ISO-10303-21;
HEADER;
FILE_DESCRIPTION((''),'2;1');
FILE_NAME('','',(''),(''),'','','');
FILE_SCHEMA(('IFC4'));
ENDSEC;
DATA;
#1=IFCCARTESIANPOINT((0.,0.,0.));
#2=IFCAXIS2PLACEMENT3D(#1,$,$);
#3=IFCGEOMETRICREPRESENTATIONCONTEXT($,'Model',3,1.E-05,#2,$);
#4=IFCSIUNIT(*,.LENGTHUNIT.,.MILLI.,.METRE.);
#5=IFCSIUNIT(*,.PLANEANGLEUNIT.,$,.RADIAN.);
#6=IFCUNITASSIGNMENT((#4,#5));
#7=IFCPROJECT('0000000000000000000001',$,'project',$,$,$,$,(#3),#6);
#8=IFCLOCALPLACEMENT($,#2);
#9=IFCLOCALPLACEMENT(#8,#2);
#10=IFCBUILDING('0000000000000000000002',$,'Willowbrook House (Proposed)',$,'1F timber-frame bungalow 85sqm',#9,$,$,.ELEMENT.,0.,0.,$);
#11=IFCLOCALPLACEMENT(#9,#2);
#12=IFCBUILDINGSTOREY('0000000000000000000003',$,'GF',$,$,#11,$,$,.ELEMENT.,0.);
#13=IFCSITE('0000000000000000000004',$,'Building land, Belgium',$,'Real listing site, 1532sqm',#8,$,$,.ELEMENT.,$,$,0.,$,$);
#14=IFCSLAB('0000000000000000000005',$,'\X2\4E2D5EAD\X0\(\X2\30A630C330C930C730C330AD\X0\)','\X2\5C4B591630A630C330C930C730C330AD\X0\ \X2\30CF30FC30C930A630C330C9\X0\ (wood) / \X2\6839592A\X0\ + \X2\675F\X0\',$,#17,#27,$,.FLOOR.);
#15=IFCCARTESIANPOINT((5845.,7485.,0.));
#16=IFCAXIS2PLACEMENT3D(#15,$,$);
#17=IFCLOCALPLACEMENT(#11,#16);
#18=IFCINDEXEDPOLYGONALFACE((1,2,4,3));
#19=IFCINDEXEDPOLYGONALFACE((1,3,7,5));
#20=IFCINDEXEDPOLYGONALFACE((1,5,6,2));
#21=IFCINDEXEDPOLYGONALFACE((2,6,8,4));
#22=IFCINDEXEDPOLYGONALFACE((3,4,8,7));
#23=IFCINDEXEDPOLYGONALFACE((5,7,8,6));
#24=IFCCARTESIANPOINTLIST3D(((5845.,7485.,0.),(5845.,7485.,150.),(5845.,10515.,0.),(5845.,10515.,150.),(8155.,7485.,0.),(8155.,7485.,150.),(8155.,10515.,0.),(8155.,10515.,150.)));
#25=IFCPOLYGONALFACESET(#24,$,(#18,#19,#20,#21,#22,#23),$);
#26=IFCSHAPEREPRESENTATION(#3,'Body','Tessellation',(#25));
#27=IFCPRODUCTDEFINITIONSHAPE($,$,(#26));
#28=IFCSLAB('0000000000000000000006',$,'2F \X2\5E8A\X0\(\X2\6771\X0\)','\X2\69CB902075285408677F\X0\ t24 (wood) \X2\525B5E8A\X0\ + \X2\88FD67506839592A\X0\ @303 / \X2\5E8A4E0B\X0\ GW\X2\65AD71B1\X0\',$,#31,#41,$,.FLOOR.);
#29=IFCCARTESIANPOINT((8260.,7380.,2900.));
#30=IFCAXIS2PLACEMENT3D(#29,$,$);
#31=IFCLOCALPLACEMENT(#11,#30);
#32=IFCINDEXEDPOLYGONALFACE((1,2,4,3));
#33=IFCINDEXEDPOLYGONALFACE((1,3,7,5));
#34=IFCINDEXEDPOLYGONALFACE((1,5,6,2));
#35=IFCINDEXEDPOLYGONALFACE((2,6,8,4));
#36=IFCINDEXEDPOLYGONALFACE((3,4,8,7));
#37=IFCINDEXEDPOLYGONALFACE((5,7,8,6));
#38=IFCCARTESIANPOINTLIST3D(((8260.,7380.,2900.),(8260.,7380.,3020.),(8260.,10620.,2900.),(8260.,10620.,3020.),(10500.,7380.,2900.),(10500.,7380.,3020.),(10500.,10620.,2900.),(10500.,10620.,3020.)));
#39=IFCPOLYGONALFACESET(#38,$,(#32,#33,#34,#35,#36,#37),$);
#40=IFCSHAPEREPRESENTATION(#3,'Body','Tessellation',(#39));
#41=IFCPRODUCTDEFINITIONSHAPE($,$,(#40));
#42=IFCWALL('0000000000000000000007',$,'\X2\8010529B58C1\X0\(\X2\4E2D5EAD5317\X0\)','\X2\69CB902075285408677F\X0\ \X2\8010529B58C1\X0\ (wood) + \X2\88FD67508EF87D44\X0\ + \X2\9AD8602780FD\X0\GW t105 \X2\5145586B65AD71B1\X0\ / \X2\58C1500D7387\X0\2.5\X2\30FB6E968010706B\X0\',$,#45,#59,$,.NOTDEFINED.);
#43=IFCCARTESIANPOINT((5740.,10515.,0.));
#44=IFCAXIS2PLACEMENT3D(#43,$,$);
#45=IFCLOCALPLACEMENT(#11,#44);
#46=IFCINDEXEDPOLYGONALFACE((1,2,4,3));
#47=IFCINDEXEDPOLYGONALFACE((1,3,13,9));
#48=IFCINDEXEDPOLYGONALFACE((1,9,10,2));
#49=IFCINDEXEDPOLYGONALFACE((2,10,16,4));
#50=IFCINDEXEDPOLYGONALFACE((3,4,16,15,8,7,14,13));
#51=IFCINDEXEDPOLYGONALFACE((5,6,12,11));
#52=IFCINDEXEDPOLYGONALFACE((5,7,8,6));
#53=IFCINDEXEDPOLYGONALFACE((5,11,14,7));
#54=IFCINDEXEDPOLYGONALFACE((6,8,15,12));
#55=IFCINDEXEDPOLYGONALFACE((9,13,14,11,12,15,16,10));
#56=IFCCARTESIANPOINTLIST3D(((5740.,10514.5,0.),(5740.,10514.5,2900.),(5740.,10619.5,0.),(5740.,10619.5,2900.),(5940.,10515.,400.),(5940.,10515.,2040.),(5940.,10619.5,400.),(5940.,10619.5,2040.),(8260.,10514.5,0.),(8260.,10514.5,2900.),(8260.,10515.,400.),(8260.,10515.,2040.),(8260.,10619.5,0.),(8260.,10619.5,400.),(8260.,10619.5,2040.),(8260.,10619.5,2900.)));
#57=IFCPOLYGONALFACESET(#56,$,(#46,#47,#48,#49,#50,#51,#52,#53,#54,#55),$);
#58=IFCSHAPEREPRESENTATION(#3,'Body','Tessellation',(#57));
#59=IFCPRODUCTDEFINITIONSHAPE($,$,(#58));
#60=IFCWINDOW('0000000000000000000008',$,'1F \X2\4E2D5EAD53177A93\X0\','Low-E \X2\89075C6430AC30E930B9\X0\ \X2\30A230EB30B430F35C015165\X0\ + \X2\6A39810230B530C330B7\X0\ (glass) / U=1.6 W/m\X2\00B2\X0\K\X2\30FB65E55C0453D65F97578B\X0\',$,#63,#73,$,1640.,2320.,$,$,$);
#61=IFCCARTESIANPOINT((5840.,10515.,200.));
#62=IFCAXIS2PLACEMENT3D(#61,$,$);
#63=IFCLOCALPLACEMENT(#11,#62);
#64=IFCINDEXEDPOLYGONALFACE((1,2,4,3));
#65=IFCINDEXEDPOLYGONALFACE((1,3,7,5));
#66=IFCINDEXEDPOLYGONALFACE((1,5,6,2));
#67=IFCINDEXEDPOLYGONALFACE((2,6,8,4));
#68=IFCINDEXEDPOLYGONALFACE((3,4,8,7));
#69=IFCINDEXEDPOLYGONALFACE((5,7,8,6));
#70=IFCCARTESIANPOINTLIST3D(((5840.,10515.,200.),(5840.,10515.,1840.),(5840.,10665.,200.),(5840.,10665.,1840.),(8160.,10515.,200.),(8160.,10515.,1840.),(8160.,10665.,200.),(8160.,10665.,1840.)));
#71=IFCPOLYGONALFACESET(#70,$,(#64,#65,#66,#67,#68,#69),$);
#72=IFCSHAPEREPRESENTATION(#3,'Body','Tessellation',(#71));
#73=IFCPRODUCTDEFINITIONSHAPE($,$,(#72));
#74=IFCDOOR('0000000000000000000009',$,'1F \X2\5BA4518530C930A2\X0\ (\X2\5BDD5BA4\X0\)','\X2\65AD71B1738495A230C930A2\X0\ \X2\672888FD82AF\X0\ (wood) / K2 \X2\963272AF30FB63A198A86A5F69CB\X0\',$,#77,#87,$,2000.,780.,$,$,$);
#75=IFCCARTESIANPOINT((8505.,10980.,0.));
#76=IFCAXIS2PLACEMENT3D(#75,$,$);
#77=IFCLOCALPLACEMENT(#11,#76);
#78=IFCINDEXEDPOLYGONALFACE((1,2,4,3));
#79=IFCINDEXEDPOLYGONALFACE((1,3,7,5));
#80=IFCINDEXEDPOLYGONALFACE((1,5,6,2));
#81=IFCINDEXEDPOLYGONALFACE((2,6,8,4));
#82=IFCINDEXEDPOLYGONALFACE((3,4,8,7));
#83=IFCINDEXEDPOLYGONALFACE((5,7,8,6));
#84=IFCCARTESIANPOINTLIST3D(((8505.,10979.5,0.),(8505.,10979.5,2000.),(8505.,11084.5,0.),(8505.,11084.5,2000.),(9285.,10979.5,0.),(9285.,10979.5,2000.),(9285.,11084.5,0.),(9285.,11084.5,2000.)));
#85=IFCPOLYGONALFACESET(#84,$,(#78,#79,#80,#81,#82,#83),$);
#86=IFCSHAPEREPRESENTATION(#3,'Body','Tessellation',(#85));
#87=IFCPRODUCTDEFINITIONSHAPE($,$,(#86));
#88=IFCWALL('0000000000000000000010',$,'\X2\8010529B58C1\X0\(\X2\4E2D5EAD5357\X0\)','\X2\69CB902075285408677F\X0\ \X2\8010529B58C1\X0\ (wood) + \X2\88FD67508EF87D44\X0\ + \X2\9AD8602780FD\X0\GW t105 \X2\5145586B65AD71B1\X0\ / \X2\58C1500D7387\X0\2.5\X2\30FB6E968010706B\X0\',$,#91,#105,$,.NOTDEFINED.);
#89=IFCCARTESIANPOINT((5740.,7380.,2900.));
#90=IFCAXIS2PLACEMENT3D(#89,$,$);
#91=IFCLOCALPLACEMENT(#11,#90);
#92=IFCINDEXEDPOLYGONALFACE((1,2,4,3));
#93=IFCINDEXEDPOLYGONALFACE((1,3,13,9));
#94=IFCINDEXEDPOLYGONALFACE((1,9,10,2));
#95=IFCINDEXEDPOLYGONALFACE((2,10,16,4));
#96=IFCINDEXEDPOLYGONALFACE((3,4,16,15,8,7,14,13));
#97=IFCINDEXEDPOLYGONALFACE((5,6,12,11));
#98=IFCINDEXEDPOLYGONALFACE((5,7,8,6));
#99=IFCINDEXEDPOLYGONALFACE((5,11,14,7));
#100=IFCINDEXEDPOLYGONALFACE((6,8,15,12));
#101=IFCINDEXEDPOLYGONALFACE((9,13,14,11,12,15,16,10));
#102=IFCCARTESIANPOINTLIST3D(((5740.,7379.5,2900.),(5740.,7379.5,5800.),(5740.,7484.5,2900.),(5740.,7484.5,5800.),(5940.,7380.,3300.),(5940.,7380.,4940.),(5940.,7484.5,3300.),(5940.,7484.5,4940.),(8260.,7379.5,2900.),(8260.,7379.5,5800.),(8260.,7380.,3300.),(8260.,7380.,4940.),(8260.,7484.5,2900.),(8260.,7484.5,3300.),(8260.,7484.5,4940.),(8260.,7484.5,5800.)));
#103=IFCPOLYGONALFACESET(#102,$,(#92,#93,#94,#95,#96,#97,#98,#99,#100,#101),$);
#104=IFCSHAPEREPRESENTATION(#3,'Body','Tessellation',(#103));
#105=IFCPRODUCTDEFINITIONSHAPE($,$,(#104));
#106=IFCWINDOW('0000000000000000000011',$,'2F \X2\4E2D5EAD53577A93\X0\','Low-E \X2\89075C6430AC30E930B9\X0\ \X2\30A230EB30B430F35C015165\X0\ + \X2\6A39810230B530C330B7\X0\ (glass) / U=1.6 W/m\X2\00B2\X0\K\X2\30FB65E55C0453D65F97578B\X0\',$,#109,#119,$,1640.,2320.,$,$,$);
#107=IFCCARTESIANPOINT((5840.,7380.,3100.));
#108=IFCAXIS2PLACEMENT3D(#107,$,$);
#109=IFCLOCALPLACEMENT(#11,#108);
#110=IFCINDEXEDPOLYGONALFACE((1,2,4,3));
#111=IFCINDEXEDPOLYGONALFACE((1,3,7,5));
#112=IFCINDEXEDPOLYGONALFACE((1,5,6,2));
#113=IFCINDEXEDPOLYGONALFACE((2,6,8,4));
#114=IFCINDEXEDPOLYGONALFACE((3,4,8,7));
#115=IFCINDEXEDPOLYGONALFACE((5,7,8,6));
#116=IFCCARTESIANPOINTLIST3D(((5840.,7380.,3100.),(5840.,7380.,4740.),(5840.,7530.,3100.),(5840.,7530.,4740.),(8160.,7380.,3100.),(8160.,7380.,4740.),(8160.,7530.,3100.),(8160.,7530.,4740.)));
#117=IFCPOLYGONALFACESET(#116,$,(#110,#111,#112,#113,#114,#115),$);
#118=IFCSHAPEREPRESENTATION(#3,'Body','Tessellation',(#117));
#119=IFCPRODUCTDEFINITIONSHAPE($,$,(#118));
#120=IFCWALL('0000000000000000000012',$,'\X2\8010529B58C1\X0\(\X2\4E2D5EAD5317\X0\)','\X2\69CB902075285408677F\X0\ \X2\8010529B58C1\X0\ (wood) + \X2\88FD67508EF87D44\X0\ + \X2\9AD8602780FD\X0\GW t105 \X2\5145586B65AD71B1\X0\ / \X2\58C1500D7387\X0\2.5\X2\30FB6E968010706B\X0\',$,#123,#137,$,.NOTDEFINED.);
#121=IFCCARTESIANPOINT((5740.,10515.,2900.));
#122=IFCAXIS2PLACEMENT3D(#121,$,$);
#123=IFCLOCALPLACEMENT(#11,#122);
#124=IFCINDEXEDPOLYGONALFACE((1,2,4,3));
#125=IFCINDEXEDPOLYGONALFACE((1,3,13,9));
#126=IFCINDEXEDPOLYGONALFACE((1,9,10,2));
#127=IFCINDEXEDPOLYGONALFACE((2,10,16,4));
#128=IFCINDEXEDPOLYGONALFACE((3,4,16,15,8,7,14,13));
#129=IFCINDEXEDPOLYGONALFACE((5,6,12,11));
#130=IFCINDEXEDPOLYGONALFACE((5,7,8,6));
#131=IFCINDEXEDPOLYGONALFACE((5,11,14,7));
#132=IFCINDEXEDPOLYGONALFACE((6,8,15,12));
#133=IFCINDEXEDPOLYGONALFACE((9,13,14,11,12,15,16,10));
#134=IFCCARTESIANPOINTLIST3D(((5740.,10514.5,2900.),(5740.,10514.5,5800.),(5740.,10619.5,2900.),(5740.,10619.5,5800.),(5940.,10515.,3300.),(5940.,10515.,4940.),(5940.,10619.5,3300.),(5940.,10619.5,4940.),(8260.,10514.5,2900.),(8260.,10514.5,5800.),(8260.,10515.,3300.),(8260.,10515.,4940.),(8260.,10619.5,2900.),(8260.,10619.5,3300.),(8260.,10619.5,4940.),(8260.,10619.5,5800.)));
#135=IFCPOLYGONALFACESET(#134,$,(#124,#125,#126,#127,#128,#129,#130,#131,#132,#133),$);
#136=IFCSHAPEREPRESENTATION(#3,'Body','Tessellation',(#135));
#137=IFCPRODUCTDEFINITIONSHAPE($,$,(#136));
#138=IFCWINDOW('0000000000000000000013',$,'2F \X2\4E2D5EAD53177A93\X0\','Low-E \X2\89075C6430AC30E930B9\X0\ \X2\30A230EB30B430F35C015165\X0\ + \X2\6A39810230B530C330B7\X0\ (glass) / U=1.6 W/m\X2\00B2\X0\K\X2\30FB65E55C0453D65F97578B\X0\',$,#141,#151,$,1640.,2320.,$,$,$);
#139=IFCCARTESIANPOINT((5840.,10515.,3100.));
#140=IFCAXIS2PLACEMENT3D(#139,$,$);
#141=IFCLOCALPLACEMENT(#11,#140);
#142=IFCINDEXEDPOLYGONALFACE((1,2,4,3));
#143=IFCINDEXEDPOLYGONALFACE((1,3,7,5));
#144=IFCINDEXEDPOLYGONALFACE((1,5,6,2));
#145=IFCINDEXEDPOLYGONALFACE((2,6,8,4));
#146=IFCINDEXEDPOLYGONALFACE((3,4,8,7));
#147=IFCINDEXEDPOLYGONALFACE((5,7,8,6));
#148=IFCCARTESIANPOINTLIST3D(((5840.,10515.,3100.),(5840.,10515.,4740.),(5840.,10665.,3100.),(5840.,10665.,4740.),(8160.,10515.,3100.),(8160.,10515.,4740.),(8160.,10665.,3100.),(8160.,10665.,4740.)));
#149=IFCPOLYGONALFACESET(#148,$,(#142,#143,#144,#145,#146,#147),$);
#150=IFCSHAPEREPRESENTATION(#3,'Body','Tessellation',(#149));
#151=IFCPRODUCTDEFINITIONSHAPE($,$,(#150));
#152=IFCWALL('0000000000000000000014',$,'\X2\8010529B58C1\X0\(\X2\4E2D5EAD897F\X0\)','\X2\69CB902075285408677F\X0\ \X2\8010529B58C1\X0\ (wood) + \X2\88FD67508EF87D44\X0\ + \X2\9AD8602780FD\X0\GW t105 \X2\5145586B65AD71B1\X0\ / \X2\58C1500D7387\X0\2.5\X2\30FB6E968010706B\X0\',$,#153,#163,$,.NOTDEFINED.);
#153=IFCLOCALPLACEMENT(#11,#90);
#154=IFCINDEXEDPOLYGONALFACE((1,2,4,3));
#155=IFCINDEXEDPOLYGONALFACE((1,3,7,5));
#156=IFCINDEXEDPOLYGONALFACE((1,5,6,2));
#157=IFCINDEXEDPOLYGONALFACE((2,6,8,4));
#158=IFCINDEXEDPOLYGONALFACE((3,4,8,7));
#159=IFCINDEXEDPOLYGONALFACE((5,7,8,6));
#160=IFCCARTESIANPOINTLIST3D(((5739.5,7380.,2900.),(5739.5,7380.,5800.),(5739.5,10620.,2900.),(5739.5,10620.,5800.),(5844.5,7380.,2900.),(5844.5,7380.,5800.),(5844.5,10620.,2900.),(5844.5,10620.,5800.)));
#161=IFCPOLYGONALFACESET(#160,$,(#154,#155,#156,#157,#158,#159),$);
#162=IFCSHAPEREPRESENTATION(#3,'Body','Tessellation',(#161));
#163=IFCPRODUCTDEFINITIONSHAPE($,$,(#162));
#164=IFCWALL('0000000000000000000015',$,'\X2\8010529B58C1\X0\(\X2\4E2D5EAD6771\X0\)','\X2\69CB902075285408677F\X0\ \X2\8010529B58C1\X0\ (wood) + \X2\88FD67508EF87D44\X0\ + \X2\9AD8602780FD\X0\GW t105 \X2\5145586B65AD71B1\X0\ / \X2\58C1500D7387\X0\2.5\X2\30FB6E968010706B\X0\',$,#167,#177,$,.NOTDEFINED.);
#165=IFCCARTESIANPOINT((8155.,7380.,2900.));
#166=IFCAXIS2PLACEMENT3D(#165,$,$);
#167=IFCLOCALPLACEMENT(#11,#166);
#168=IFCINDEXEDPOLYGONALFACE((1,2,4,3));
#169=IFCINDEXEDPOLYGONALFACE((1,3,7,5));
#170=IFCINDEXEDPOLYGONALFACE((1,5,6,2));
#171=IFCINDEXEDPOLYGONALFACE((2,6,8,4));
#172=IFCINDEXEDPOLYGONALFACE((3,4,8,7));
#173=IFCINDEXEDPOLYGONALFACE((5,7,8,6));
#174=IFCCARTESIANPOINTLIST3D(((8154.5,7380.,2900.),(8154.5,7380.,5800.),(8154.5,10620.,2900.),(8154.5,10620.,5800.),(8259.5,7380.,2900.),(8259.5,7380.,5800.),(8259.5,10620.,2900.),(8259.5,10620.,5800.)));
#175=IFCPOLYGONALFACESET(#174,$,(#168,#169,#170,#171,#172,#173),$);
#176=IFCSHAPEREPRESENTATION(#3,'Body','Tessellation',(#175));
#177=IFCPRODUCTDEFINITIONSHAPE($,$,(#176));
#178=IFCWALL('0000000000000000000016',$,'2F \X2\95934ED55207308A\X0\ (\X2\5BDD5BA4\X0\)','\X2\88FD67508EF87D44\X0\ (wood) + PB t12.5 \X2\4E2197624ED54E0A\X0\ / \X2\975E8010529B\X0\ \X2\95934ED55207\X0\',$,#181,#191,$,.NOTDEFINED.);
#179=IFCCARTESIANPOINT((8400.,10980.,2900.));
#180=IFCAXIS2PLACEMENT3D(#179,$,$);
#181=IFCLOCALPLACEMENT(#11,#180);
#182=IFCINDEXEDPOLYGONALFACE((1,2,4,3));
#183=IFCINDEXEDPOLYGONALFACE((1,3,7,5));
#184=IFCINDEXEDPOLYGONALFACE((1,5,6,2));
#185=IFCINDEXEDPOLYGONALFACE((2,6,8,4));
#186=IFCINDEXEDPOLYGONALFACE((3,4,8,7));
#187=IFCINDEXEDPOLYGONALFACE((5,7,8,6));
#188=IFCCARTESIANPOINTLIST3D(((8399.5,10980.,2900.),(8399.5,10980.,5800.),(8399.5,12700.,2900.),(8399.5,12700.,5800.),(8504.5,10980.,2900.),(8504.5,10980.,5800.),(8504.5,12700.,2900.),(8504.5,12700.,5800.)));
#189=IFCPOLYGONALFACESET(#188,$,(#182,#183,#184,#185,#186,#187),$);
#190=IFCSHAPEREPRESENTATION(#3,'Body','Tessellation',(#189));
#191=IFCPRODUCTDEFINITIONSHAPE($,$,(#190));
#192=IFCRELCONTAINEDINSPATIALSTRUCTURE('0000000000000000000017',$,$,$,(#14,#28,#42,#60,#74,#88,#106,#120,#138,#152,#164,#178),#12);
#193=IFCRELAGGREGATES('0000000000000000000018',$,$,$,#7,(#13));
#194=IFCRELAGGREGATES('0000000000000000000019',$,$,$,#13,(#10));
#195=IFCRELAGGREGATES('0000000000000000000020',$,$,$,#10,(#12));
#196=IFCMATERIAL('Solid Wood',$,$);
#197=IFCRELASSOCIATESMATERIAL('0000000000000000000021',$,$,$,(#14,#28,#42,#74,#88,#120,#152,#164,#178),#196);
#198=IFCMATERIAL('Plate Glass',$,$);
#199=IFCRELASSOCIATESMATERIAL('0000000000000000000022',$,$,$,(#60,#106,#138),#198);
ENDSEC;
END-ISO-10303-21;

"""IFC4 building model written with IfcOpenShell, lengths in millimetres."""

from ifc_helpers import new_model, si_unit, frame, frame_2d, origin, place, context, project, spatial, rectangle, extrude, material, element, fill, save


model = new_model("IFC4")

# Units and contexts
model_context = context("Model", 3, precision=1e-05, world=origin())
ifc_project = project(units=[si_unit("LENGTHUNIT", "METRE", prefix="MILLI"), si_unit("PLANEANGLEUNIT", "RADIAN")], contexts=[model_context])

# Site, building, storey
site_placement = place(None, origin())
site = spatial("IfcSite", under=ifc_project, at=site_placement, Name="Building land, Belgium", ObjectType="Real listing site, 1532sqm", CompositionType="ELEMENT", RefElevation=0.0)
building_placement = place(site_placement, origin())
building = spatial("IfcBuilding", under=site, at=building_placement, Name="Willowbrook House (Proposed)", ObjectType="1F timber-frame bungalow 85sqm", CompositionType="ELEMENT", ElevationOfRefHeight=0.0, ElevationOfTerrain=0.0)
storey_placement = place(building_placement, origin())
storey = spatial("IfcBuildingStorey", under=building, at=storey_placement, Name="GF", CompositionType="ELEMENT", Elevation=0.0)

# Slabs
ifc_material_1 = material(Name="Solid Wood")
slab_1_placement = place(storey_placement, frame((5845.0, 7485.0, 0.0)))
element("IfcSlab", 1, at=slab_1_placement, inside=storey, material=ifc_material_1, Name="中庭(ウッドデッキ)", Description="屋外ウッドデッキ ハードウッド (wood) / 根太 + 束", PredefinedType="FLOOR", context=model_context, shape_type="SweptSolid", body=[
    extrude(rectangle(XDim=2310.0, YDim=3030.0, at=frame_2d((1155.0, 1515.0))), frame((5845.0, 7485.0, 0.0)), (0.0, 0.0, 1.0), 150.0),
])
slab_2_placement = place(storey_placement, frame((8260.0, 7380.0, 2900.0)))
element("IfcSlab", 2, at=slab_2_placement, inside=storey, material=ifc_material_1, Name="2F 床(東)", Description="構造用合板 t24 (wood) 剛床 + 製材根太 @303 / 床下 GW断熱", PredefinedType="FLOOR", context=model_context, shape_type="SweptSolid", body=[
    extrude(rectangle(XDim=2240.0, YDim=3240.0, at=frame_2d((1120.0, 1620.0))), frame((8260.0, 7380.0, 2900.0)), (0.0, 0.0, 1.0), 120.0),
])

# Wall, opening, window
wall_1_placement = place(storey_placement, frame((5740.0, 10515.0, 0.0)))
wall_1 = element("IfcWall", 3, at=wall_1_placement, inside=storey, material=ifc_material_1, Name="耐力壁(中庭北)", Description="構造用合板 耐力壁 (wood) + 製材軸組 + 高性能GW t105 充填断熱 / 壁倍率2.5・準耐火", PredefinedType="NOTDEFINED", context=model_context, shape_type="SweptSolid", body=[
    extrude(rectangle(XDim=2520.0, YDim=105.0, at=frame_2d((1260.0, 52.0))), frame((5740.0, 10515.0, 0.0)), (0.0, 0.0, 1.0), 2900.0),
])
opening_1_placement = place(storey_placement, frame((5840.0, 10515.0, 200.0)))
opening_1 = element("IfcOpeningElement", 4, at=opening_1_placement, cuts=wall_1, PredefinedType="NOTDEFINED", context=model_context, shape_type="SweptSolid", body=[
    extrude(rectangle(XDim=2320.0, YDim=150.0, at=frame_2d((1160.0, 75.0))), frame((5840.0, 10515.0, 200.0)), (0.0, 0.0, 1.0), 1640.0),
])
ifc_material_2 = material(Name="Plate Glass")
window_1_placement = place(storey_placement, frame((5840.0, 10515.0, 200.0)))
window_1 = element("IfcWindow", 5, at=window_1_placement, inside=storey, material=ifc_material_2, Name="1F 中庭北窓", Description="Low-E 複層ガラス アルゴン封入 + 樹脂サッシ (glass) / U=1.6 W/m²K・日射取得型", OverallHeight=1640.0, OverallWidth=2320.0, context=model_context, shape_type="SweptSolid", body=[
    extrude(rectangle(XDim=2320.0, YDim=150.0, at=frame_2d((1160.0, 75.0))), frame((5840.0, 10515.0, 200.0)), (0.0, 0.0, 1.0), 1640.0),
])
fill(opening_1, window_1)

# Door
door_1_placement = place(storey_placement, frame((8505.0, 10980.0, 0.0)))
element("IfcDoor", 6, at=door_1_placement, inside=storey, material=ifc_material_1, Name="1F 室内ドア (寝室)", Description="断熱玄関ドア 木製芯 (wood) / K2 防犯・採風機構", OverallHeight=2000.0, OverallWidth=780.0, context=model_context, shape_type="SweptSolid", body=[
    extrude(rectangle(XDim=780.0, YDim=105.0, at=frame_2d((390.0, 52.0))), frame((8505.0, 10980.0, 0.0)), (0.0, 0.0, 1.0), 2000.0),
])

# Walls, openings, windows
wall_2_placement = place(storey_placement, frame((5740.0, 7380.0, 2900.0)))
wall_2 = element("IfcWall", 7, at=wall_2_placement, inside=storey, material=ifc_material_1, Name="耐力壁(中庭南)", Description="構造用合板 耐力壁 (wood) + 製材軸組 + 高性能GW t105 充填断熱 / 壁倍率2.5・準耐火", PredefinedType="NOTDEFINED", context=model_context, shape_type="SweptSolid", body=[
    extrude(rectangle(XDim=2520.0, YDim=105.0, at=frame_2d((1260.0, 52.0))), frame((5740.0, 7380.0, 2900.0)), (0.0, 0.0, 1.0), 2900.0),
])
opening_2_placement = place(storey_placement, frame((5840.0, 7380.0, 3100.0)))
opening_2 = element("IfcOpeningElement", 8, at=opening_2_placement, cuts=wall_2, PredefinedType="NOTDEFINED", context=model_context, shape_type="SweptSolid", body=[
    extrude(rectangle(XDim=2320.0, YDim=150.0, at=frame_2d((1160.0, 75.0))), frame((5840.0, 7380.0, 3100.0)), (0.0, 0.0, 1.0), 1640.0),
])
window_2_placement = place(storey_placement, frame((5840.0, 7380.0, 3100.0)))
window_2 = element("IfcWindow", 9, at=window_2_placement, inside=storey, material=ifc_material_2, Name="2F 中庭南窓", Description="Low-E 複層ガラス アルゴン封入 + 樹脂サッシ (glass) / U=1.6 W/m²K・日射取得型", OverallHeight=1640.0, OverallWidth=2320.0, context=model_context, shape_type="SweptSolid", body=[
    extrude(rectangle(XDim=2320.0, YDim=150.0, at=frame_2d((1160.0, 75.0))), frame((5840.0, 7380.0, 3100.0)), (0.0, 0.0, 1.0), 1640.0),
])
fill(opening_2, window_2)
wall_3_placement = place(storey_placement, frame((5740.0, 10515.0, 2900.0)))
wall_3 = element("IfcWall", 10, at=wall_3_placement, inside=storey, material=ifc_material_1, Name="耐力壁(中庭北)", Description="構造用合板 耐力壁 (wood) + 製材軸組 + 高性能GW t105 充填断熱 / 壁倍率2.5・準耐火", PredefinedType="NOTDEFINED", context=model_context, shape_type="SweptSolid", body=[
    extrude(rectangle(XDim=2520.0, YDim=105.0, at=frame_2d((1260.0, 52.0))), frame((5740.0, 10515.0, 2900.0)), (0.0, 0.0, 1.0), 2900.0),
])
opening_3_placement = place(storey_placement, frame((5840.0, 10515.0, 3100.0)))
opening_3 = element("IfcOpeningElement", 11, at=opening_3_placement, cuts=wall_3, PredefinedType="NOTDEFINED", context=model_context, shape_type="SweptSolid", body=[
    extrude(rectangle(XDim=2320.0, YDim=150.0, at=frame_2d((1160.0, 75.0))), frame((5840.0, 10515.0, 3100.0)), (0.0, 0.0, 1.0), 1640.0),
])
window_3_placement = place(storey_placement, frame((5840.0, 10515.0, 3100.0)))
window_3 = element("IfcWindow", 12, at=window_3_placement, inside=storey, material=ifc_material_2, Name="2F 中庭北窓", Description="Low-E 複層ガラス アルゴン封入 + 樹脂サッシ (glass) / U=1.6 W/m²K・日射取得型", OverallHeight=1640.0, OverallWidth=2320.0, context=model_context, shape_type="SweptSolid", body=[
    extrude(rectangle(XDim=2320.0, YDim=150.0, at=frame_2d((1160.0, 75.0))), frame((5840.0, 10515.0, 3100.0)), (0.0, 0.0, 1.0), 1640.0),
])
fill(opening_3, window_3)

# Walls
wall_4_placement = place(storey_placement, frame((5740.0, 7380.0, 2900.0)))
element("IfcWall", 13, at=wall_4_placement, inside=storey, material=ifc_material_1, Name="耐力壁(中庭西)", Description="構造用合板 耐力壁 (wood) + 製材軸組 + 高性能GW t105 充填断熱 / 壁倍率2.5・準耐火", PredefinedType="NOTDEFINED", context=model_context, shape_type="SweptSolid", body=[
    extrude(rectangle(XDim=105.0, YDim=3240.0, at=frame_2d((52.0, 1620.0))), frame((5740.0, 7380.0, 2900.0)), (0.0, 0.0, 1.0), 2900.0),
])
wall_5_placement = place(storey_placement, frame((8155.0, 7380.0, 2900.0)))
element("IfcWall", 14, at=wall_5_placement, inside=storey, material=ifc_material_1, Name="耐力壁(中庭東)", Description="構造用合板 耐力壁 (wood) + 製材軸組 + 高性能GW t105 充填断熱 / 壁倍率2.5・準耐火", PredefinedType="NOTDEFINED", context=model_context, shape_type="SweptSolid", body=[
    extrude(rectangle(XDim=105.0, YDim=3240.0, at=frame_2d((52.0, 1620.0))), frame((8155.0, 7380.0, 2900.0)), (0.0, 0.0, 1.0), 2900.0),
])
wall_6_placement = place(storey_placement, frame((8400.0, 10980.0, 2900.0)))
element("IfcWall", 15, at=wall_6_placement, inside=storey, material=ifc_material_1, Name="2F 間仕切り (寝室)", Description="製材軸組 (wood) + PB t12.5 両面仕上 / 非耐力 間仕切", PredefinedType="NOTDEFINED", context=model_context, shape_type="SweptSolid", body=[
    extrude(rectangle(XDim=105.0, YDim=1720.0, at=frame_2d((52.0, 860.0))), frame((8400.0, 10980.0, 2900.0)), (0.0, 0.0, 1.0), 2900.0),
])

save(model, "model.ifc")
